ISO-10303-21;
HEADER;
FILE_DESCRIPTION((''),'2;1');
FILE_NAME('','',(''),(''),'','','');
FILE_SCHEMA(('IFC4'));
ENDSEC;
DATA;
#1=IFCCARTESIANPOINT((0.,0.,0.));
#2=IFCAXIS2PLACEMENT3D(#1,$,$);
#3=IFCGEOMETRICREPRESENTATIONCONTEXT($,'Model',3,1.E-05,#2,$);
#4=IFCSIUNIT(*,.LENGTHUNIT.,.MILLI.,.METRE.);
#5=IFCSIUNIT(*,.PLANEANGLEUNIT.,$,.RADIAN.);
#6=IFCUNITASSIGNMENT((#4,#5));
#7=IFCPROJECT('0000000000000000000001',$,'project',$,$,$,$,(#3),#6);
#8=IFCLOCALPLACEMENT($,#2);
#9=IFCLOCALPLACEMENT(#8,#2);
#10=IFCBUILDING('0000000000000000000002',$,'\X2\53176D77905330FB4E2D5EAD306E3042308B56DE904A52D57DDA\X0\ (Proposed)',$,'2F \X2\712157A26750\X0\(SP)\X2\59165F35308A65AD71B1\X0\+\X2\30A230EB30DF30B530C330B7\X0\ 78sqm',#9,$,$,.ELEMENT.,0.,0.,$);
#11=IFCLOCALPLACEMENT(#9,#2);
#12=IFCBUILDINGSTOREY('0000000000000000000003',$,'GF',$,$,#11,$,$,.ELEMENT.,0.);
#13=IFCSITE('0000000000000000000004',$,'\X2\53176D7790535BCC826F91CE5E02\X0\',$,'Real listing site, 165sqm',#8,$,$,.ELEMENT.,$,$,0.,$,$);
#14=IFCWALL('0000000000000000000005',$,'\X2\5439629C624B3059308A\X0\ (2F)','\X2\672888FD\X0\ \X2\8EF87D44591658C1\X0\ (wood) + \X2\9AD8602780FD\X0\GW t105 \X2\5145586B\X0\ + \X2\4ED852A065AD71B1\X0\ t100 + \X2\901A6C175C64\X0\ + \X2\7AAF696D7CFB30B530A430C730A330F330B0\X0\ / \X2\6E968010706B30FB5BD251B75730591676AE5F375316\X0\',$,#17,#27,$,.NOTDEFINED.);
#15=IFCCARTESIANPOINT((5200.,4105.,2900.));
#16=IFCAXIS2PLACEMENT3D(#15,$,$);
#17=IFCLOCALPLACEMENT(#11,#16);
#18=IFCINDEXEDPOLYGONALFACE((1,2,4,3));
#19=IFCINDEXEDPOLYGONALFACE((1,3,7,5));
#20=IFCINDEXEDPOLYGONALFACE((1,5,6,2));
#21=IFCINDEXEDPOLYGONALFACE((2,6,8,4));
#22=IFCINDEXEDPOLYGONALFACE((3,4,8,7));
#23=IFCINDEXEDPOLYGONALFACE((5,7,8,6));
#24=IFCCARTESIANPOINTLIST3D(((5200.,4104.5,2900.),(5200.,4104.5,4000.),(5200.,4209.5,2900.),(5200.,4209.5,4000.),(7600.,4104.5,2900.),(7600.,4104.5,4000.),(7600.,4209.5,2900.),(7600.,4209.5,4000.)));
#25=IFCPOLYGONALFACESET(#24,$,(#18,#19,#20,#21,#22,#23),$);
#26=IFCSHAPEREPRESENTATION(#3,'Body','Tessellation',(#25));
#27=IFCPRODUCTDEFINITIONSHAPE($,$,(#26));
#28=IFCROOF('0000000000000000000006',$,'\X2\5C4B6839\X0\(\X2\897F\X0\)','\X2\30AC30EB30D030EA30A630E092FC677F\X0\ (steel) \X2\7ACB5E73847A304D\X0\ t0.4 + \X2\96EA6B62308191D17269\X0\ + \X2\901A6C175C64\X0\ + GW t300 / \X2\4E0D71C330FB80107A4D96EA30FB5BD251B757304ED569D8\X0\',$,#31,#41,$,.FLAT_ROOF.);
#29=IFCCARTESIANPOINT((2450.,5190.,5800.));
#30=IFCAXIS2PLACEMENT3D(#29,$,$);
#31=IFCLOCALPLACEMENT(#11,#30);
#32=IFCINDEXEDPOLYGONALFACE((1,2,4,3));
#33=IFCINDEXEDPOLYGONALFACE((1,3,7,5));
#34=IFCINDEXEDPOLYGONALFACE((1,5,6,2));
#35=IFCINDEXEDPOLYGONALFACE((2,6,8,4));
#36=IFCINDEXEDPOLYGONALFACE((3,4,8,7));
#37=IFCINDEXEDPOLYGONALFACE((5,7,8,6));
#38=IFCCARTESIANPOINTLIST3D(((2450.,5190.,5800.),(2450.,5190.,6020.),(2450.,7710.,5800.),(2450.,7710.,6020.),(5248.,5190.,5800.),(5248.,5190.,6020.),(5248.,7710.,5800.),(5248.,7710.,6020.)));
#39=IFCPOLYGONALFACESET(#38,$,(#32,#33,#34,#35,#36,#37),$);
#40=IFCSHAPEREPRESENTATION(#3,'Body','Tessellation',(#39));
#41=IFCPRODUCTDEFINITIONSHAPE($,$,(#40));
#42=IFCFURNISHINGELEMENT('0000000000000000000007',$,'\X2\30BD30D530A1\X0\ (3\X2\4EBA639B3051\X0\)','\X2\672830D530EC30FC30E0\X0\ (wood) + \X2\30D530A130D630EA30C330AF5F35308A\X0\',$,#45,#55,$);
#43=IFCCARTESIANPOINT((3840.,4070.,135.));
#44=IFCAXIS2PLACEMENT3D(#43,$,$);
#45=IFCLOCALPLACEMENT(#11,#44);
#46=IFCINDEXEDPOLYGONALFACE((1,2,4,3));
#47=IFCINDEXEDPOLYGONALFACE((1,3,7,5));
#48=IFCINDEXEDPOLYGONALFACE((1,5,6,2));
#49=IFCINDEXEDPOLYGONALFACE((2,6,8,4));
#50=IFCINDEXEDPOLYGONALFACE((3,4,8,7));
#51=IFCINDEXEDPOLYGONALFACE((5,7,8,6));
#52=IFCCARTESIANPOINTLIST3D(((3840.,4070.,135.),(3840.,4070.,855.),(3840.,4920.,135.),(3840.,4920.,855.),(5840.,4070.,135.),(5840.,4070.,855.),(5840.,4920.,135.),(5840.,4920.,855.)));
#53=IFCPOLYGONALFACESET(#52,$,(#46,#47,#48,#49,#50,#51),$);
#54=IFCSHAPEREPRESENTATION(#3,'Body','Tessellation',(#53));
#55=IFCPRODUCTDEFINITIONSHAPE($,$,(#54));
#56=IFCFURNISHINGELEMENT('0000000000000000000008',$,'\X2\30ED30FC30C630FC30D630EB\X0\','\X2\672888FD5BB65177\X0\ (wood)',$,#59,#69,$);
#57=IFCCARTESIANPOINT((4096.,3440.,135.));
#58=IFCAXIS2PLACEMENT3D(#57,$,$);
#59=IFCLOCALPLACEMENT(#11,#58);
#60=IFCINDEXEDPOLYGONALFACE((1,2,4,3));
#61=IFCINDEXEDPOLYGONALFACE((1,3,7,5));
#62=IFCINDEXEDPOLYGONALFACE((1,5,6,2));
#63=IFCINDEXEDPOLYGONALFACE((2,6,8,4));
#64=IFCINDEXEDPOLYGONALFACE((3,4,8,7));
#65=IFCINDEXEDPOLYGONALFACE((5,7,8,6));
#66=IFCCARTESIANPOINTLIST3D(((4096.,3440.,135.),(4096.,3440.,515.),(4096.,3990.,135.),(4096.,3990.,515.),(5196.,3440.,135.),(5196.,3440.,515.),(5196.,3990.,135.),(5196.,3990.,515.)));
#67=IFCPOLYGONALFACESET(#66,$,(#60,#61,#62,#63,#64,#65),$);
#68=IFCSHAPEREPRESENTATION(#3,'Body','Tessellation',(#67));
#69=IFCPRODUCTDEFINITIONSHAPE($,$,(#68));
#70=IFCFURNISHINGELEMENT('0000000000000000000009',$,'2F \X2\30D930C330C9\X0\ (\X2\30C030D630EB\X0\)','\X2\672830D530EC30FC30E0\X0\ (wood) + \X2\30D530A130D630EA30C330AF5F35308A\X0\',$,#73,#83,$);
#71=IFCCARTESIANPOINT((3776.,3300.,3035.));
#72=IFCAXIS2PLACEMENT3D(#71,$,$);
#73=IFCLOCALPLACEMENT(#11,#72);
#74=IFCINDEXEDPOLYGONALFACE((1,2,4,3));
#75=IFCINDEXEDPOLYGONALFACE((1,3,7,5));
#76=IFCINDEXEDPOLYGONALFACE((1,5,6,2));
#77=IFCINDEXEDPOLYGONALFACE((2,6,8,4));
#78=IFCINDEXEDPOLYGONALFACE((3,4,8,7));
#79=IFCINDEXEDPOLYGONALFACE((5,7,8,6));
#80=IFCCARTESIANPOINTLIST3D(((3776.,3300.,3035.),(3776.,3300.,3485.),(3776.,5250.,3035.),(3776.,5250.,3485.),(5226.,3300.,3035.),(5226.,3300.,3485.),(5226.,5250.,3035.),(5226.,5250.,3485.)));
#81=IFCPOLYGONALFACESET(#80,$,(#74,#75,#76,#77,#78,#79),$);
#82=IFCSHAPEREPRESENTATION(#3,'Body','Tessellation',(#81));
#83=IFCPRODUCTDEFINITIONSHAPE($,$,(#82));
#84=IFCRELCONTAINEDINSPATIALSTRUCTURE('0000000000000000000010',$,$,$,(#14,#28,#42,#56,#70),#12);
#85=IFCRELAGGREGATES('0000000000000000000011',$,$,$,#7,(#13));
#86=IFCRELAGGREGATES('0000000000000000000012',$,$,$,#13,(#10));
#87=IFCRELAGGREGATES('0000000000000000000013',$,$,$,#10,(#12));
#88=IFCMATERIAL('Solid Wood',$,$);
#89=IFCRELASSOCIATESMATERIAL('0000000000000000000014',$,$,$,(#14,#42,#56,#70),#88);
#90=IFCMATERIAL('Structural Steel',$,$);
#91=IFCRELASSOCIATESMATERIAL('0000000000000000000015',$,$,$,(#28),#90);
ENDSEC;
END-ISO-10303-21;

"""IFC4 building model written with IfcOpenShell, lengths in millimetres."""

from ifc_helpers import new_model, si_unit, frame, frame_2d, origin, place, context, project, spatial, rectangle, extrude, material, element, save


model = new_model("IFC4")

# Units and contexts
model_context = context("Model", 3, precision=1e-05, world=origin())
ifc_project = project(units=[si_unit("LENGTHUNIT", "METRE", prefix="MILLI"), si_unit("PLANEANGLEUNIT", "RADIAN")], contexts=[model_context])

# Site, building, storey
site_placement = place(None, origin())
site = spatial("IfcSite", under=ifc_project, at=site_placement, Name="北海道富良野市", ObjectType="Real listing site, 165sqm", CompositionType="ELEMENT", RefElevation=0.0)
building_placement = place(site_placement, origin())
building = spatial("IfcBuilding", under=site, at=building_placement, Name="北海道・中庭のある回遊動線 (Proposed)", ObjectType="2F 無垢材(SP)外張り断熱+アルミサッシ 78sqm", CompositionType="ELEMENT", ElevationOfRefHeight=0.0, ElevationOfTerrain=0.0)
storey_placement = place(building_placement, origin())
storey = spatial("IfcBuildingStorey", under=building, at=storey_placement, Name="GF", CompositionType="ELEMENT", Elevation=0.0)

# Shared definitions
ifc_material_1 = material(Name="Solid Wood")

# Wall
wall_placement = place(storey_placement, frame((5200.0, 4105.0, 2900.0)))
element("IfcWall", 1, at=wall_placement, inside=storey, material=ifc_material_1, Name="吹抜手すり (2F)", Description="木製 軸組外壁 (wood) + 高性能GW t105 充填 + 付加断熱 t100 + 通気層 + 窯業系サイディング / 準耐火・寒冷地外皮強化", PredefinedType="NOTDEFINED", context=model_context, shape_type="SweptSolid", body=[
    extrude(rectangle(XDim=2400.0, YDim=105.0, at=frame_2d((1200.0, 52.0))), frame((5200.0, 4105.0, 2900.0)), (0.0, 0.0, 1.0), 1100.0),
])

# Roof
ifc_material_2 = material(Name="Structural Steel")
for number, where, name in (
    (2, (2450.0, 5190.0, 5800.0), "屋根(西)"),
):
    element("IfcRoof", number, at=place(storey_placement, frame(where)), inside=storey, material=ifc_material_2, Name=name, Description="ガルバリウム鋼板 (steel) 立平葺き t0.4 + 雪止め金物 + 通気層 + GW t300 / 不燃・耐積雪・寒冷地仕様", PredefinedType="FLAT_ROOF", context=model_context, shape_type="SweptSolid", body=[
        extrude(rectangle(XDim=2798.0, YDim=2520.0, at=frame_2d((1399.0, 1260.0))), frame((2450.0, 5190.0, 5800.0)), (0.0, 0.0, 1.0), 220.0),
    ])

# Furnishing elements
furnishing_1_placement = place(storey_placement, frame((3840.0, 4070.0, 135.0)))
element("IfcFurnishingElement", 3, at=furnishing_1_placement, inside=storey, material=ifc_material_1, Name="ソファ (3人掛け)", Description="木フレーム (wood) + ファブリック張り", context=model_context, shape_type="SweptSolid", body=[
    extrude(rectangle(XDim=2000.0, YDim=850.0, at=frame_2d((1000.0, 425.0))), frame((3840.0, 4070.0, 135.0)), (0.0, 0.0, 1.0), 720.0),
])
furnishing_2_placement = place(storey_placement, frame((4096.0, 3440.0, 135.0)))
element("IfcFurnishingElement", 4, at=furnishing_2_placement, inside=storey, material=ifc_material_1, Name="ローテーブル", Description="木製家具 (wood)", context=model_context, shape_type="SweptSolid", body=[
    extrude(rectangle(XDim=1100.0, YDim=550.0, at=frame_2d((550.0, 275.0))), frame((4096.0, 3440.0, 135.0)), (0.0, 0.0, 1.0), 380.0),
])
furnishing_3_placement = place(storey_placement, frame((3776.0, 3300.0, 3035.0)))
element("IfcFurnishingElement", 5, at=furnishing_3_placement, inside=storey, material=ifc_material_1, Name="2F ベッド (ダブル)", Description="木フレーム (wood) + ファブリック張り", context=model_context, shape_type="SweptSolid", body=[
    extrude(rectangle(XDim=1450.0, YDim=1950.0, at=frame_2d((725.0, 975.0))), frame((3776.0, 3300.0, 3035.0)), (0.0, 0.0, 1.0), 450.0),
])

save(model, "model.ifc")
